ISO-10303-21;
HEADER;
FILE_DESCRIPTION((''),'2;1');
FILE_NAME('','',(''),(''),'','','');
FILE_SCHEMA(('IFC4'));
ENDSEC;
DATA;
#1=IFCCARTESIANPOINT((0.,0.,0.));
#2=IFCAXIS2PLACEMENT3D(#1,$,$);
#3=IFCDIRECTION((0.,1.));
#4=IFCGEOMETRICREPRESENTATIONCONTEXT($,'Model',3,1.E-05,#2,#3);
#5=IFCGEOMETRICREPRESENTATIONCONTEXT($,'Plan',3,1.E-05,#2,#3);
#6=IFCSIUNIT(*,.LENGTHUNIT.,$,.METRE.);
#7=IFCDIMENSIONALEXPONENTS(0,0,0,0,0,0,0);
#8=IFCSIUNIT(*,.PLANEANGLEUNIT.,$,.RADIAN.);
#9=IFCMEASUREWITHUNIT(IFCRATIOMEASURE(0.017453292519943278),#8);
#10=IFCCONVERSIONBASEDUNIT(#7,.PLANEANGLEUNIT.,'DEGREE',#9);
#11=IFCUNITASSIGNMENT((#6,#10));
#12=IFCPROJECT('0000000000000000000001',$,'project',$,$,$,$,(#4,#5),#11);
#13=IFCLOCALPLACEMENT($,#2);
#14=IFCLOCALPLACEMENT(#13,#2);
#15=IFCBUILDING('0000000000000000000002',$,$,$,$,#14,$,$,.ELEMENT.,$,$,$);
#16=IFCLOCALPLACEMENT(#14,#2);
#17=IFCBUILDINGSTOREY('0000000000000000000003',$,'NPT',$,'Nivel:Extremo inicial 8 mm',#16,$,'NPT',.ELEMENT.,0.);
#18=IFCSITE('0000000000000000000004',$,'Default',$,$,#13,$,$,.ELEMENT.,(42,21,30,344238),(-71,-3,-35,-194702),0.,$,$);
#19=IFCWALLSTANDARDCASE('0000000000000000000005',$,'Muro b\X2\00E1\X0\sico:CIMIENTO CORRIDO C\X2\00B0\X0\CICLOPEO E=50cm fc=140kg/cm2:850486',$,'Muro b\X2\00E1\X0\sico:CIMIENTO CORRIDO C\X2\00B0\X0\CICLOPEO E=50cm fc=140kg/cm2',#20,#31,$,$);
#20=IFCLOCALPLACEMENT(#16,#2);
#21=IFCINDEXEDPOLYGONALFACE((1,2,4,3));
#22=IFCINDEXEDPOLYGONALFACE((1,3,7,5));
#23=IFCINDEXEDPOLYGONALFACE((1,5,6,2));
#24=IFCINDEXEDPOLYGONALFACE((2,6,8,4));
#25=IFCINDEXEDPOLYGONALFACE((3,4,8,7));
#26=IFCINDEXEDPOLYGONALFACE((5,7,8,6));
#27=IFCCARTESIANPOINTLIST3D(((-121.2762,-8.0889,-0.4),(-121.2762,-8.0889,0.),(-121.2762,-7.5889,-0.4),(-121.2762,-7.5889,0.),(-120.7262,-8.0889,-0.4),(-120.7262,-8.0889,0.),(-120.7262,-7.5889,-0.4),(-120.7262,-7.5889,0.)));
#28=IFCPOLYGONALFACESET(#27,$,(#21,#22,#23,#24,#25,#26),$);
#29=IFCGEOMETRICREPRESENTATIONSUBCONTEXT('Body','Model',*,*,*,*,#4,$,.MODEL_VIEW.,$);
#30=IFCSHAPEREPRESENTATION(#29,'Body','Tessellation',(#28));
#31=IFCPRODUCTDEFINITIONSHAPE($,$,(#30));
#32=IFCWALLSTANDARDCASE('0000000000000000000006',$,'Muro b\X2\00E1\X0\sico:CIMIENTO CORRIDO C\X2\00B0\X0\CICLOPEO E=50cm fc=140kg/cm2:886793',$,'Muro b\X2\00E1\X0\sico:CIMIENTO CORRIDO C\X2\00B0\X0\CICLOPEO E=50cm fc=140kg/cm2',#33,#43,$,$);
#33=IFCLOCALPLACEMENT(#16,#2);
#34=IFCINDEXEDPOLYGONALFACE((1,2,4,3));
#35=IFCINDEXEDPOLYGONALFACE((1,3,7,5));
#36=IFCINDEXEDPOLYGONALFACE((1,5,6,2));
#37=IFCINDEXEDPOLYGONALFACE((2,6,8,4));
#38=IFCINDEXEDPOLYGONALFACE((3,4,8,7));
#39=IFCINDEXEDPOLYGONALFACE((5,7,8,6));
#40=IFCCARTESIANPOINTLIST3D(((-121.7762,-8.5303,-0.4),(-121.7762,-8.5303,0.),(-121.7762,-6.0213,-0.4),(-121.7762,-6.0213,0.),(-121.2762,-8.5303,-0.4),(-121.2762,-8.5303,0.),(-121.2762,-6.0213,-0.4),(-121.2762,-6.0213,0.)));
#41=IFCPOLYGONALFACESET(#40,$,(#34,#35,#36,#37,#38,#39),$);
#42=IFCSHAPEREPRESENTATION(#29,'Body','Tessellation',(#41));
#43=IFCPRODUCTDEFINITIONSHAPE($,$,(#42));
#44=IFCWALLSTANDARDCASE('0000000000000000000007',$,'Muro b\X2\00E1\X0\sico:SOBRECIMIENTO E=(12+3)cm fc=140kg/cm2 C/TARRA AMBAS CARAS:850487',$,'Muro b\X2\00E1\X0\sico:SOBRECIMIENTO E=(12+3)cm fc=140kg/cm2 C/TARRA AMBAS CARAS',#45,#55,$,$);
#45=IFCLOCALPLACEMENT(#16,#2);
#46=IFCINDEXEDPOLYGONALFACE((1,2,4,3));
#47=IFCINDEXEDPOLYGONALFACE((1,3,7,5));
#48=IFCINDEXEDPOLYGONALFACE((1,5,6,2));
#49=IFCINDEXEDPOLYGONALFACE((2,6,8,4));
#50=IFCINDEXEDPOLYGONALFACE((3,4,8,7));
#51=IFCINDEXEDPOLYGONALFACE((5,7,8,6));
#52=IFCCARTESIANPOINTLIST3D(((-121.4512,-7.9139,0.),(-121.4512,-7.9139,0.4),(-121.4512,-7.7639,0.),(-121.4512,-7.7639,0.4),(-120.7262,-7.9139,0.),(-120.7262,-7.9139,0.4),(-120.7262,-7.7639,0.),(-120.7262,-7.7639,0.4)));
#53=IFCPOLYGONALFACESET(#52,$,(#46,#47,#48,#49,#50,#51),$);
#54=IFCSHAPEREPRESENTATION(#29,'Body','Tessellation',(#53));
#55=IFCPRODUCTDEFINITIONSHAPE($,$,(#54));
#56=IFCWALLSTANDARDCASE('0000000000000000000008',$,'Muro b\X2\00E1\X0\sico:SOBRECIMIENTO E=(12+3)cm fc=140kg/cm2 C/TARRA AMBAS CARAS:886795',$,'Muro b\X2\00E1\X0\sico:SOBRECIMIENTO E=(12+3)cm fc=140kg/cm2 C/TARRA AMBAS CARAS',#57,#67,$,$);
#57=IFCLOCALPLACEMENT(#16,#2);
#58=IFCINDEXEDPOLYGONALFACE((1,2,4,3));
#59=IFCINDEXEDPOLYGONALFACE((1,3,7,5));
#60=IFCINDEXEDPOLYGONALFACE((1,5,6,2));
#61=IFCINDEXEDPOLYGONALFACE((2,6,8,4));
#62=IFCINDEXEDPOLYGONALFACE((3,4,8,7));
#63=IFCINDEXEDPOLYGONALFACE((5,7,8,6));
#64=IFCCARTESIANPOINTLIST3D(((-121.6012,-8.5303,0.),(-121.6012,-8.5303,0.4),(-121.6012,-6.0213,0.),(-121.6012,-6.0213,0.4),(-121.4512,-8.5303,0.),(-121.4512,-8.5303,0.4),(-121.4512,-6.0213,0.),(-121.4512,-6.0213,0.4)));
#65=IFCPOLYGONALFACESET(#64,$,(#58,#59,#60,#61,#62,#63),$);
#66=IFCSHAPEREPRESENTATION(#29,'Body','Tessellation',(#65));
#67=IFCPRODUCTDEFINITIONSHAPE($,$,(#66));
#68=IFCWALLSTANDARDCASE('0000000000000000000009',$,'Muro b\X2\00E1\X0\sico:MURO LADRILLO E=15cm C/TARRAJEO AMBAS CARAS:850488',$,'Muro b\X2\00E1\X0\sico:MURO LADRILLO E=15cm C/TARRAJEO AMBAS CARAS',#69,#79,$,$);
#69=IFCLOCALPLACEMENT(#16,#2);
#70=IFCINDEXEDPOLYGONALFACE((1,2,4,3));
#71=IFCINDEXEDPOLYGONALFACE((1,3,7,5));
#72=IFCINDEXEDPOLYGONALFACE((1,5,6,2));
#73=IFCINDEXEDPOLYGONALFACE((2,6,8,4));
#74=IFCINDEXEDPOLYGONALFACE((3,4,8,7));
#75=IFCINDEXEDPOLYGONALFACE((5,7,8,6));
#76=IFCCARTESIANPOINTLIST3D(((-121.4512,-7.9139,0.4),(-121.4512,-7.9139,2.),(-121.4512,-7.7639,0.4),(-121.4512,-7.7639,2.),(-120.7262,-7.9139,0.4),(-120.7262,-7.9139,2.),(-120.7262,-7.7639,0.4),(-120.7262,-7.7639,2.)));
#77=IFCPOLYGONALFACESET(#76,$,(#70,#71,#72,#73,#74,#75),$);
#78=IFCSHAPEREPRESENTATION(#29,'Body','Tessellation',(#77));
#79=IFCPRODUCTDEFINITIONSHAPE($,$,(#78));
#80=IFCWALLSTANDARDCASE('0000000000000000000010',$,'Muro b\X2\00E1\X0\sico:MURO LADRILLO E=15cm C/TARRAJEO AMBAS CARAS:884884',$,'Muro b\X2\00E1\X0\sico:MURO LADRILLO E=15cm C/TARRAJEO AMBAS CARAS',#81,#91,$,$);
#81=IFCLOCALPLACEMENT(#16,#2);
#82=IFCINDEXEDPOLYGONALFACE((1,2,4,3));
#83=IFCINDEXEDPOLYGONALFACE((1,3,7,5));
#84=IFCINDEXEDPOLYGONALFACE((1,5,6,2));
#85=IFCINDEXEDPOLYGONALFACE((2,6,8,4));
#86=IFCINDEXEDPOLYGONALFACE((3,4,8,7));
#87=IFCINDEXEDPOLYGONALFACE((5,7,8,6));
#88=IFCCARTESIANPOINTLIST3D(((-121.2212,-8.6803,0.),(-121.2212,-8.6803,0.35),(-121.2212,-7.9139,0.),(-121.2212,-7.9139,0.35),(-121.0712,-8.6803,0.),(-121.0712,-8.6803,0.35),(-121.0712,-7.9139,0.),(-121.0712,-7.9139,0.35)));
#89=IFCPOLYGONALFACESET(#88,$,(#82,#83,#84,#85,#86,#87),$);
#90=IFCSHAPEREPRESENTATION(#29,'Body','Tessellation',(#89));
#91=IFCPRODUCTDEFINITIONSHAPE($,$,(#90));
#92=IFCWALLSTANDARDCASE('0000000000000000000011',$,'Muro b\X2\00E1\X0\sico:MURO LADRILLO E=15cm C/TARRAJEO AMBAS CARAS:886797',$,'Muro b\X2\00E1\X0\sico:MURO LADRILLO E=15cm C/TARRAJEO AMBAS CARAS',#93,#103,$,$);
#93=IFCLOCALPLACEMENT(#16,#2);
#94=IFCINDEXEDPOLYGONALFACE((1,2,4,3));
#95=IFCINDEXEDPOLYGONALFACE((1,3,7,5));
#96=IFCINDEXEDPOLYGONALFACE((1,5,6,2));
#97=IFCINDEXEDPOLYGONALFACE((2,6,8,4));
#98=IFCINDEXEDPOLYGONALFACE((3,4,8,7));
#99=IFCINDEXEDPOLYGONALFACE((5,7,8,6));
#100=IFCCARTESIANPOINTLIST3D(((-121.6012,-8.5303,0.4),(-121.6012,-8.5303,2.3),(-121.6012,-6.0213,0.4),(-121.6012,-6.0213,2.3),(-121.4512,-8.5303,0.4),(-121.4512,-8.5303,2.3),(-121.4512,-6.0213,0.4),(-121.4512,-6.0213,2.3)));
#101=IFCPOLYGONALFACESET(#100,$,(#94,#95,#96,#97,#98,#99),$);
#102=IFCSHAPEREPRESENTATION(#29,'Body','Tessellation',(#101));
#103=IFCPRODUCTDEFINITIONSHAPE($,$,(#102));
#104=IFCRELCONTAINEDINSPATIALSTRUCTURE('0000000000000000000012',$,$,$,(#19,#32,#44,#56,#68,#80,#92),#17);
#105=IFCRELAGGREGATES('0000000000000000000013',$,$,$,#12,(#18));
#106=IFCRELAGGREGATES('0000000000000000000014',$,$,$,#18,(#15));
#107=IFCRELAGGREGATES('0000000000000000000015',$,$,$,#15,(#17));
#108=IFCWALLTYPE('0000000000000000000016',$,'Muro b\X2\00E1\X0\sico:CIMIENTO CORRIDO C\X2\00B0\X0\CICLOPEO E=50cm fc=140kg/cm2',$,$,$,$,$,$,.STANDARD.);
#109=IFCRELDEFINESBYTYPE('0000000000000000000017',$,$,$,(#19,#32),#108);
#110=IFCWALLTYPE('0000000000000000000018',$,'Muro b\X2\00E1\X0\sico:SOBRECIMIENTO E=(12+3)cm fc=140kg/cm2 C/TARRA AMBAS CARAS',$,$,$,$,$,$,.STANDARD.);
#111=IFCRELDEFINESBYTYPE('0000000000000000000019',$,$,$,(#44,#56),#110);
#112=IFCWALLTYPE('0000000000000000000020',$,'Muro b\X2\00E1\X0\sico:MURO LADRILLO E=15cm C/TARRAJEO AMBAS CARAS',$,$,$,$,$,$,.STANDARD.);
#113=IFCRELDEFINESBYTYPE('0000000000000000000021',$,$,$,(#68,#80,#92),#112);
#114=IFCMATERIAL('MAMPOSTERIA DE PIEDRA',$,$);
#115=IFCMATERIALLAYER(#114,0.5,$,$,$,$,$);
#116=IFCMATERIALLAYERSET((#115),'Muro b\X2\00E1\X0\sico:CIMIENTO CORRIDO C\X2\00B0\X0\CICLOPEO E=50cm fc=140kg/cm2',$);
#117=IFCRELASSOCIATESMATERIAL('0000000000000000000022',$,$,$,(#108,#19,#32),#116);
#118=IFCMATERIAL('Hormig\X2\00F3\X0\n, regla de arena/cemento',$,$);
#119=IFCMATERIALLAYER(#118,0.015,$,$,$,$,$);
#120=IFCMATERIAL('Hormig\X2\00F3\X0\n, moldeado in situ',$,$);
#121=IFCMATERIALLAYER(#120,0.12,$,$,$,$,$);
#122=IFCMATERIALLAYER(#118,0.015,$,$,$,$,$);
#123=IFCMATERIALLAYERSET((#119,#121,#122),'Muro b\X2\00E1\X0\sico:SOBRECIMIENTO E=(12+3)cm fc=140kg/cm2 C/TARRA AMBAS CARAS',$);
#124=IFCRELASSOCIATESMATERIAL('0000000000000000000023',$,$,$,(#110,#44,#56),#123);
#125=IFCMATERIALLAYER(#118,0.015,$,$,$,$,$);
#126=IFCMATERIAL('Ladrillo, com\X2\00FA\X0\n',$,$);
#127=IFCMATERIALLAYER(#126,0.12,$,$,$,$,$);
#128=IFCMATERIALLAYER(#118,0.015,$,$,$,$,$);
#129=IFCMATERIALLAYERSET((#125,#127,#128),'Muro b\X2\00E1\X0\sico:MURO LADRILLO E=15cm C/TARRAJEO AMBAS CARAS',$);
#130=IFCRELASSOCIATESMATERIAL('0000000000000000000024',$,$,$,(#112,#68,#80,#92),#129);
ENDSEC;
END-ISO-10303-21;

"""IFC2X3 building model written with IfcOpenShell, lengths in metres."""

from ifc_helpers import new_model, entity, si_unit, converted_unit, direction, frame, frame_2d, origin, place, context, subcontext, project, spatial, rectangle, extrude, material, layer, layer_set, layer_usage, type_object, element, save


model = new_model("IFC2X3")

# Units and contexts
model_context = context("Model", 3, precision=1e-05, world=origin(), true_north=direction((0.0, 1.0)))
plan_context = context("Plan", 3, precision=1e-05, world=origin(), true_north=direction((0.0, 1.0)))
body_context = subcontext(model_context, "Body", "Model", "MODEL_VIEW")
ifc_project = project(units=[si_unit("LENGTHUNIT", "METRE"), converted_unit("PLANEANGLEUNIT", "DEGREE", entity("IfcRatioMeasure", 0.017453292519943278), si_unit("PLANEANGLEUNIT", "RADIAN"), dimensions=[0, 0, 0, 0, 0, 0, 0])], contexts=[model_context, plan_context])

# Site, building, storey
site_placement = place(None, origin())
site = spatial("IfcSite", under=ifc_project, at=site_placement, Name="Default", CompositionType="ELEMENT", RefLatitude=(42, 21, 30, 344238), RefLongitude=(-71, -3, -35, -194702), RefElevation=0.0)
building_placement = place(site_placement, origin())
building = spatial("IfcBuilding", under=site, at=building_placement, CompositionType="ELEMENT")
storey_placement = place(building_placement, origin())
storey = spatial("IfcBuildingStorey", under=building, at=storey_placement, Name="NPT", ObjectType="Nivel:Extremo inicial 8 mm", LongName="NPT", CompositionType="ELEMENT", Elevation=0.0)

# Shared definitions
ifc_material_1 = material(Name="Hormigón, moldeado in situ")

# Walls
ifc_material_2 = material(Name="MAMPOSTERIA DE PIEDRA")
ifc_layer_1 = layer(ifc_material_2, 0.5)
ifc_layer_set_1 = layer_set([ifc_layer_1], Name="Muro básico:CIMIENTO CORRIDO C°CICLOPEO E=50cm fc=140kg/cm2")
ifc_layer_usage_1 = layer_usage(ifc_layer_set_1, "AXIS2", "POSITIVE", -0.25)
wall_type_1 = type_object("IfcWallType", Name="Muro básico:CIMIENTO CORRIDO C°CICLOPEO E=50cm fc=140kg/cm2", PredefinedType="STANDARD", material=ifc_layer_set_1)
wall_1_placement = place(storey_placement, frame((-121.2762, -7.8389, -0.4)))
element("IfcWallStandardCase", 1, at=wall_1_placement, inside=storey, type_object=wall_type_1, material=ifc_layer_usage_1, Name="Muro básico:CIMIENTO CORRIDO C°CICLOPEO E=50cm fc=140kg/cm2:850486", ObjectType="Muro básico:CIMIENTO CORRIDO C°CICLOPEO E=50cm fc=140kg/cm2", context=body_context, shape_type="SweptSolid", body=[
    extrude(rectangle(XDim=0.55, YDim=0.5, at=frame_2d((0.275, 0.0), x_axis=(-1.0, 0.0))), origin(), (0.0, 0.0, 1.0), 0.4),
])
ifc_layer_usage_2 = layer_usage(ifc_layer_set_1, "AXIS2", "NEGATIVE", 0.25)
wall_2_placement = place(storey_placement, frame((-121.5262, -6.0213, -0.4), z_axis=(0.0, 0.0, 1.0), x_axis=(0.0, -1.0, 0.0)))
element("IfcWallStandardCase", 2, at=wall_2_placement, inside=storey, type_object=wall_type_1, material=ifc_layer_usage_2, Name="Muro básico:CIMIENTO CORRIDO C°CICLOPEO E=50cm fc=140kg/cm2:886793", ObjectType="Muro básico:CIMIENTO CORRIDO C°CICLOPEO E=50cm fc=140kg/cm2", context=body_context, shape_type="SweptSolid", body=[
    extrude(rectangle(XDim=2.5091, YDim=0.5, at=frame_2d((1.2545, 0.0), x_axis=(-1.0, 0.0))), origin(), (0.0, 0.0, 1.0), 0.4),
])
ifc_material_3 = material(Name="Hormigón, regla de arena/cemento")
ifc_layer_2 = layer(ifc_material_3, 0.015)
ifc_layer_3 = layer(ifc_material_1, 0.12)
ifc_layer_4 = layer(ifc_material_3, 0.015)
ifc_layer_set_2 = layer_set([ifc_layer_2, ifc_layer_3, ifc_layer_4], Name="Muro básico:SOBRECIMIENTO E=(12+3)cm fc=140kg/cm2 C/TARRA AMBAS CARAS")
ifc_layer_usage_3 = layer_usage(ifc_layer_set_2, "AXIS2", "POSITIVE", -0.075)
wall_type_2 = type_object("IfcWallType", Name="Muro básico:SOBRECIMIENTO E=(12+3)cm fc=140kg/cm2 C/TARRA AMBAS CARAS", PredefinedType="STANDARD", material=ifc_layer_set_2)
wall_3_placement = place(storey_placement, frame((-121.4512, -7.8389, 0.0)))
element("IfcWallStandardCase", 3, at=wall_3_placement, inside=storey, type_object=wall_type_2, material=ifc_layer_usage_3, Name="Muro básico:SOBRECIMIENTO E=(12+3)cm fc=140kg/cm2 C/TARRA AMBAS CARAS:850487", ObjectType="Muro básico:SOBRECIMIENTO E=(12+3)cm fc=140kg/cm2 C/TARRA AMBAS CARAS", context=body_context, shape_type="SweptSolid", body=[
    extrude(rectangle(XDim=0.725, YDim=0.15, at=frame_2d((0.3625, 0.0), x_axis=(-1.0, 0.0))), origin(), (0.0, 0.0, 1.0), 0.4),
])
ifc_layer_usage_4 = layer_usage(ifc_layer_set_2, "AXIS2", "NEGATIVE", 0.075)
wall_4_placement = place(storey_placement, frame((-121.5262, -6.0213, 0.0), z_axis=(0.0, 0.0, 1.0), x_axis=(0.0, -1.0, 0.0)))
element("IfcWallStandardCase", 4, at=wall_4_placement, inside=storey, type_object=wall_type_2, material=ifc_layer_usage_4, Name="Muro básico:SOBRECIMIENTO E=(12+3)cm fc=140kg/cm2 C/TARRA AMBAS CARAS:886795", ObjectType="Muro básico:SOBRECIMIENTO E=(12+3)cm fc=140kg/cm2 C/TARRA AMBAS CARAS", context=body_context, shape_type="SweptSolid", body=[
    extrude(rectangle(XDim=2.5091, YDim=0.15, at=frame_2d((1.2545, 0.0), x_axis=(-1.0, 0.0))), origin(), (0.0, 0.0, 1.0), 0.4),
])
ifc_layer_5 = layer(ifc_material_3, 0.015)
ifc_material_4 = material(Name="Ladrillo, común")
ifc_layer_6 = layer(ifc_material_4, 0.12)
ifc_layer_7 = layer(ifc_material_3, 0.015)
ifc_layer_set_3 = layer_set([ifc_layer_5, ifc_layer_6, ifc_layer_7], Name="Muro básico:MURO LADRILLO E=15cm C/TARRAJEO AMBAS CARAS")
ifc_layer_usage_5 = layer_usage(ifc_layer_set_3, "AXIS2", "POSITIVE", -0.075)
wall_type_3 = type_object("IfcWallType", Name="Muro básico:MURO LADRILLO E=15cm C/TARRAJEO AMBAS CARAS", PredefinedType="STANDARD", material=ifc_layer_set_3)
wall_5_placement = place(storey_placement, frame((-121.4512, -7.8389, 0.4)))
element("IfcWallStandardCase", 5, at=wall_5_placement, inside=storey, type_object=wall_type_3, material=ifc_layer_usage_5, Name="Muro básico:MURO LADRILLO E=15cm C/TARRAJEO AMBAS CARAS:850488", ObjectType="Muro básico:MURO LADRILLO E=15cm C/TARRAJEO AMBAS CARAS", context=body_context, shape_type="SweptSolid", body=[
    extrude(rectangle(XDim=0.725, YDim=0.15, at=frame_2d((0.3625, 0.0), x_axis=(-1.0, 0.0))), origin(), (0.0, 0.0, 1.0), 1.6),
])
ifc_layer_usage_6 = layer_usage(ifc_layer_set_3, "AXIS2", "NEGATIVE", 0.075)
wall_6_placement = place(storey_placement, frame((-121.1462, -8.6803, 0.0), z_axis=(0.0, 0.0, 1.0), x_axis=(0.0, 1.0, 0.0)))
element("IfcWallStandardCase", 6, at=wall_6_placement, inside=storey, type_object=wall_type_3, material=ifc_layer_usage_6, Name="Muro básico:MURO LADRILLO E=15cm C/TARRAJEO AMBAS CARAS:884884", ObjectType="Muro básico:MURO LADRILLO E=15cm C/TARRAJEO AMBAS CARAS", context=body_context, shape_type="SweptSolid", body=[
    extrude(rectangle(XDim=0.7665, YDim=0.15, at=frame_2d((0.3832, 0.0), x_axis=(-1.0, 0.0))), origin(), (0.0, 0.0, 1.0), 0.35),
])
ifc_layer_usage_7 = layer_usage(ifc_layer_set_3, "AXIS2", "NEGATIVE", 0.075)
wall_7_placement = place(storey_placement, frame((-121.5262, -6.0213, 0.4), z_axis=(0.0, 0.0, 1.0), x_axis=(0.0, -1.0, 0.0)))
element("IfcWallStandardCase", 7, at=wall_7_placement, inside=storey, type_object=wall_type_3, material=ifc_layer_usage_7, Name="Muro básico:MURO LADRILLO E=15cm C/TARRAJEO AMBAS CARAS:886797", ObjectType="Muro básico:MURO LADRILLO E=15cm C/TARRAJEO AMBAS CARAS", context=body_context, shape_type="SweptSolid", body=[
    extrude(rectangle(XDim=2.5091, YDim=0.15, at=frame_2d((1.2545, 0.0), x_axis=(-1.0, 0.0))), origin(), (0.0, 0.0, 1.0), 1.9),
])

save(model, "model.ifc")
